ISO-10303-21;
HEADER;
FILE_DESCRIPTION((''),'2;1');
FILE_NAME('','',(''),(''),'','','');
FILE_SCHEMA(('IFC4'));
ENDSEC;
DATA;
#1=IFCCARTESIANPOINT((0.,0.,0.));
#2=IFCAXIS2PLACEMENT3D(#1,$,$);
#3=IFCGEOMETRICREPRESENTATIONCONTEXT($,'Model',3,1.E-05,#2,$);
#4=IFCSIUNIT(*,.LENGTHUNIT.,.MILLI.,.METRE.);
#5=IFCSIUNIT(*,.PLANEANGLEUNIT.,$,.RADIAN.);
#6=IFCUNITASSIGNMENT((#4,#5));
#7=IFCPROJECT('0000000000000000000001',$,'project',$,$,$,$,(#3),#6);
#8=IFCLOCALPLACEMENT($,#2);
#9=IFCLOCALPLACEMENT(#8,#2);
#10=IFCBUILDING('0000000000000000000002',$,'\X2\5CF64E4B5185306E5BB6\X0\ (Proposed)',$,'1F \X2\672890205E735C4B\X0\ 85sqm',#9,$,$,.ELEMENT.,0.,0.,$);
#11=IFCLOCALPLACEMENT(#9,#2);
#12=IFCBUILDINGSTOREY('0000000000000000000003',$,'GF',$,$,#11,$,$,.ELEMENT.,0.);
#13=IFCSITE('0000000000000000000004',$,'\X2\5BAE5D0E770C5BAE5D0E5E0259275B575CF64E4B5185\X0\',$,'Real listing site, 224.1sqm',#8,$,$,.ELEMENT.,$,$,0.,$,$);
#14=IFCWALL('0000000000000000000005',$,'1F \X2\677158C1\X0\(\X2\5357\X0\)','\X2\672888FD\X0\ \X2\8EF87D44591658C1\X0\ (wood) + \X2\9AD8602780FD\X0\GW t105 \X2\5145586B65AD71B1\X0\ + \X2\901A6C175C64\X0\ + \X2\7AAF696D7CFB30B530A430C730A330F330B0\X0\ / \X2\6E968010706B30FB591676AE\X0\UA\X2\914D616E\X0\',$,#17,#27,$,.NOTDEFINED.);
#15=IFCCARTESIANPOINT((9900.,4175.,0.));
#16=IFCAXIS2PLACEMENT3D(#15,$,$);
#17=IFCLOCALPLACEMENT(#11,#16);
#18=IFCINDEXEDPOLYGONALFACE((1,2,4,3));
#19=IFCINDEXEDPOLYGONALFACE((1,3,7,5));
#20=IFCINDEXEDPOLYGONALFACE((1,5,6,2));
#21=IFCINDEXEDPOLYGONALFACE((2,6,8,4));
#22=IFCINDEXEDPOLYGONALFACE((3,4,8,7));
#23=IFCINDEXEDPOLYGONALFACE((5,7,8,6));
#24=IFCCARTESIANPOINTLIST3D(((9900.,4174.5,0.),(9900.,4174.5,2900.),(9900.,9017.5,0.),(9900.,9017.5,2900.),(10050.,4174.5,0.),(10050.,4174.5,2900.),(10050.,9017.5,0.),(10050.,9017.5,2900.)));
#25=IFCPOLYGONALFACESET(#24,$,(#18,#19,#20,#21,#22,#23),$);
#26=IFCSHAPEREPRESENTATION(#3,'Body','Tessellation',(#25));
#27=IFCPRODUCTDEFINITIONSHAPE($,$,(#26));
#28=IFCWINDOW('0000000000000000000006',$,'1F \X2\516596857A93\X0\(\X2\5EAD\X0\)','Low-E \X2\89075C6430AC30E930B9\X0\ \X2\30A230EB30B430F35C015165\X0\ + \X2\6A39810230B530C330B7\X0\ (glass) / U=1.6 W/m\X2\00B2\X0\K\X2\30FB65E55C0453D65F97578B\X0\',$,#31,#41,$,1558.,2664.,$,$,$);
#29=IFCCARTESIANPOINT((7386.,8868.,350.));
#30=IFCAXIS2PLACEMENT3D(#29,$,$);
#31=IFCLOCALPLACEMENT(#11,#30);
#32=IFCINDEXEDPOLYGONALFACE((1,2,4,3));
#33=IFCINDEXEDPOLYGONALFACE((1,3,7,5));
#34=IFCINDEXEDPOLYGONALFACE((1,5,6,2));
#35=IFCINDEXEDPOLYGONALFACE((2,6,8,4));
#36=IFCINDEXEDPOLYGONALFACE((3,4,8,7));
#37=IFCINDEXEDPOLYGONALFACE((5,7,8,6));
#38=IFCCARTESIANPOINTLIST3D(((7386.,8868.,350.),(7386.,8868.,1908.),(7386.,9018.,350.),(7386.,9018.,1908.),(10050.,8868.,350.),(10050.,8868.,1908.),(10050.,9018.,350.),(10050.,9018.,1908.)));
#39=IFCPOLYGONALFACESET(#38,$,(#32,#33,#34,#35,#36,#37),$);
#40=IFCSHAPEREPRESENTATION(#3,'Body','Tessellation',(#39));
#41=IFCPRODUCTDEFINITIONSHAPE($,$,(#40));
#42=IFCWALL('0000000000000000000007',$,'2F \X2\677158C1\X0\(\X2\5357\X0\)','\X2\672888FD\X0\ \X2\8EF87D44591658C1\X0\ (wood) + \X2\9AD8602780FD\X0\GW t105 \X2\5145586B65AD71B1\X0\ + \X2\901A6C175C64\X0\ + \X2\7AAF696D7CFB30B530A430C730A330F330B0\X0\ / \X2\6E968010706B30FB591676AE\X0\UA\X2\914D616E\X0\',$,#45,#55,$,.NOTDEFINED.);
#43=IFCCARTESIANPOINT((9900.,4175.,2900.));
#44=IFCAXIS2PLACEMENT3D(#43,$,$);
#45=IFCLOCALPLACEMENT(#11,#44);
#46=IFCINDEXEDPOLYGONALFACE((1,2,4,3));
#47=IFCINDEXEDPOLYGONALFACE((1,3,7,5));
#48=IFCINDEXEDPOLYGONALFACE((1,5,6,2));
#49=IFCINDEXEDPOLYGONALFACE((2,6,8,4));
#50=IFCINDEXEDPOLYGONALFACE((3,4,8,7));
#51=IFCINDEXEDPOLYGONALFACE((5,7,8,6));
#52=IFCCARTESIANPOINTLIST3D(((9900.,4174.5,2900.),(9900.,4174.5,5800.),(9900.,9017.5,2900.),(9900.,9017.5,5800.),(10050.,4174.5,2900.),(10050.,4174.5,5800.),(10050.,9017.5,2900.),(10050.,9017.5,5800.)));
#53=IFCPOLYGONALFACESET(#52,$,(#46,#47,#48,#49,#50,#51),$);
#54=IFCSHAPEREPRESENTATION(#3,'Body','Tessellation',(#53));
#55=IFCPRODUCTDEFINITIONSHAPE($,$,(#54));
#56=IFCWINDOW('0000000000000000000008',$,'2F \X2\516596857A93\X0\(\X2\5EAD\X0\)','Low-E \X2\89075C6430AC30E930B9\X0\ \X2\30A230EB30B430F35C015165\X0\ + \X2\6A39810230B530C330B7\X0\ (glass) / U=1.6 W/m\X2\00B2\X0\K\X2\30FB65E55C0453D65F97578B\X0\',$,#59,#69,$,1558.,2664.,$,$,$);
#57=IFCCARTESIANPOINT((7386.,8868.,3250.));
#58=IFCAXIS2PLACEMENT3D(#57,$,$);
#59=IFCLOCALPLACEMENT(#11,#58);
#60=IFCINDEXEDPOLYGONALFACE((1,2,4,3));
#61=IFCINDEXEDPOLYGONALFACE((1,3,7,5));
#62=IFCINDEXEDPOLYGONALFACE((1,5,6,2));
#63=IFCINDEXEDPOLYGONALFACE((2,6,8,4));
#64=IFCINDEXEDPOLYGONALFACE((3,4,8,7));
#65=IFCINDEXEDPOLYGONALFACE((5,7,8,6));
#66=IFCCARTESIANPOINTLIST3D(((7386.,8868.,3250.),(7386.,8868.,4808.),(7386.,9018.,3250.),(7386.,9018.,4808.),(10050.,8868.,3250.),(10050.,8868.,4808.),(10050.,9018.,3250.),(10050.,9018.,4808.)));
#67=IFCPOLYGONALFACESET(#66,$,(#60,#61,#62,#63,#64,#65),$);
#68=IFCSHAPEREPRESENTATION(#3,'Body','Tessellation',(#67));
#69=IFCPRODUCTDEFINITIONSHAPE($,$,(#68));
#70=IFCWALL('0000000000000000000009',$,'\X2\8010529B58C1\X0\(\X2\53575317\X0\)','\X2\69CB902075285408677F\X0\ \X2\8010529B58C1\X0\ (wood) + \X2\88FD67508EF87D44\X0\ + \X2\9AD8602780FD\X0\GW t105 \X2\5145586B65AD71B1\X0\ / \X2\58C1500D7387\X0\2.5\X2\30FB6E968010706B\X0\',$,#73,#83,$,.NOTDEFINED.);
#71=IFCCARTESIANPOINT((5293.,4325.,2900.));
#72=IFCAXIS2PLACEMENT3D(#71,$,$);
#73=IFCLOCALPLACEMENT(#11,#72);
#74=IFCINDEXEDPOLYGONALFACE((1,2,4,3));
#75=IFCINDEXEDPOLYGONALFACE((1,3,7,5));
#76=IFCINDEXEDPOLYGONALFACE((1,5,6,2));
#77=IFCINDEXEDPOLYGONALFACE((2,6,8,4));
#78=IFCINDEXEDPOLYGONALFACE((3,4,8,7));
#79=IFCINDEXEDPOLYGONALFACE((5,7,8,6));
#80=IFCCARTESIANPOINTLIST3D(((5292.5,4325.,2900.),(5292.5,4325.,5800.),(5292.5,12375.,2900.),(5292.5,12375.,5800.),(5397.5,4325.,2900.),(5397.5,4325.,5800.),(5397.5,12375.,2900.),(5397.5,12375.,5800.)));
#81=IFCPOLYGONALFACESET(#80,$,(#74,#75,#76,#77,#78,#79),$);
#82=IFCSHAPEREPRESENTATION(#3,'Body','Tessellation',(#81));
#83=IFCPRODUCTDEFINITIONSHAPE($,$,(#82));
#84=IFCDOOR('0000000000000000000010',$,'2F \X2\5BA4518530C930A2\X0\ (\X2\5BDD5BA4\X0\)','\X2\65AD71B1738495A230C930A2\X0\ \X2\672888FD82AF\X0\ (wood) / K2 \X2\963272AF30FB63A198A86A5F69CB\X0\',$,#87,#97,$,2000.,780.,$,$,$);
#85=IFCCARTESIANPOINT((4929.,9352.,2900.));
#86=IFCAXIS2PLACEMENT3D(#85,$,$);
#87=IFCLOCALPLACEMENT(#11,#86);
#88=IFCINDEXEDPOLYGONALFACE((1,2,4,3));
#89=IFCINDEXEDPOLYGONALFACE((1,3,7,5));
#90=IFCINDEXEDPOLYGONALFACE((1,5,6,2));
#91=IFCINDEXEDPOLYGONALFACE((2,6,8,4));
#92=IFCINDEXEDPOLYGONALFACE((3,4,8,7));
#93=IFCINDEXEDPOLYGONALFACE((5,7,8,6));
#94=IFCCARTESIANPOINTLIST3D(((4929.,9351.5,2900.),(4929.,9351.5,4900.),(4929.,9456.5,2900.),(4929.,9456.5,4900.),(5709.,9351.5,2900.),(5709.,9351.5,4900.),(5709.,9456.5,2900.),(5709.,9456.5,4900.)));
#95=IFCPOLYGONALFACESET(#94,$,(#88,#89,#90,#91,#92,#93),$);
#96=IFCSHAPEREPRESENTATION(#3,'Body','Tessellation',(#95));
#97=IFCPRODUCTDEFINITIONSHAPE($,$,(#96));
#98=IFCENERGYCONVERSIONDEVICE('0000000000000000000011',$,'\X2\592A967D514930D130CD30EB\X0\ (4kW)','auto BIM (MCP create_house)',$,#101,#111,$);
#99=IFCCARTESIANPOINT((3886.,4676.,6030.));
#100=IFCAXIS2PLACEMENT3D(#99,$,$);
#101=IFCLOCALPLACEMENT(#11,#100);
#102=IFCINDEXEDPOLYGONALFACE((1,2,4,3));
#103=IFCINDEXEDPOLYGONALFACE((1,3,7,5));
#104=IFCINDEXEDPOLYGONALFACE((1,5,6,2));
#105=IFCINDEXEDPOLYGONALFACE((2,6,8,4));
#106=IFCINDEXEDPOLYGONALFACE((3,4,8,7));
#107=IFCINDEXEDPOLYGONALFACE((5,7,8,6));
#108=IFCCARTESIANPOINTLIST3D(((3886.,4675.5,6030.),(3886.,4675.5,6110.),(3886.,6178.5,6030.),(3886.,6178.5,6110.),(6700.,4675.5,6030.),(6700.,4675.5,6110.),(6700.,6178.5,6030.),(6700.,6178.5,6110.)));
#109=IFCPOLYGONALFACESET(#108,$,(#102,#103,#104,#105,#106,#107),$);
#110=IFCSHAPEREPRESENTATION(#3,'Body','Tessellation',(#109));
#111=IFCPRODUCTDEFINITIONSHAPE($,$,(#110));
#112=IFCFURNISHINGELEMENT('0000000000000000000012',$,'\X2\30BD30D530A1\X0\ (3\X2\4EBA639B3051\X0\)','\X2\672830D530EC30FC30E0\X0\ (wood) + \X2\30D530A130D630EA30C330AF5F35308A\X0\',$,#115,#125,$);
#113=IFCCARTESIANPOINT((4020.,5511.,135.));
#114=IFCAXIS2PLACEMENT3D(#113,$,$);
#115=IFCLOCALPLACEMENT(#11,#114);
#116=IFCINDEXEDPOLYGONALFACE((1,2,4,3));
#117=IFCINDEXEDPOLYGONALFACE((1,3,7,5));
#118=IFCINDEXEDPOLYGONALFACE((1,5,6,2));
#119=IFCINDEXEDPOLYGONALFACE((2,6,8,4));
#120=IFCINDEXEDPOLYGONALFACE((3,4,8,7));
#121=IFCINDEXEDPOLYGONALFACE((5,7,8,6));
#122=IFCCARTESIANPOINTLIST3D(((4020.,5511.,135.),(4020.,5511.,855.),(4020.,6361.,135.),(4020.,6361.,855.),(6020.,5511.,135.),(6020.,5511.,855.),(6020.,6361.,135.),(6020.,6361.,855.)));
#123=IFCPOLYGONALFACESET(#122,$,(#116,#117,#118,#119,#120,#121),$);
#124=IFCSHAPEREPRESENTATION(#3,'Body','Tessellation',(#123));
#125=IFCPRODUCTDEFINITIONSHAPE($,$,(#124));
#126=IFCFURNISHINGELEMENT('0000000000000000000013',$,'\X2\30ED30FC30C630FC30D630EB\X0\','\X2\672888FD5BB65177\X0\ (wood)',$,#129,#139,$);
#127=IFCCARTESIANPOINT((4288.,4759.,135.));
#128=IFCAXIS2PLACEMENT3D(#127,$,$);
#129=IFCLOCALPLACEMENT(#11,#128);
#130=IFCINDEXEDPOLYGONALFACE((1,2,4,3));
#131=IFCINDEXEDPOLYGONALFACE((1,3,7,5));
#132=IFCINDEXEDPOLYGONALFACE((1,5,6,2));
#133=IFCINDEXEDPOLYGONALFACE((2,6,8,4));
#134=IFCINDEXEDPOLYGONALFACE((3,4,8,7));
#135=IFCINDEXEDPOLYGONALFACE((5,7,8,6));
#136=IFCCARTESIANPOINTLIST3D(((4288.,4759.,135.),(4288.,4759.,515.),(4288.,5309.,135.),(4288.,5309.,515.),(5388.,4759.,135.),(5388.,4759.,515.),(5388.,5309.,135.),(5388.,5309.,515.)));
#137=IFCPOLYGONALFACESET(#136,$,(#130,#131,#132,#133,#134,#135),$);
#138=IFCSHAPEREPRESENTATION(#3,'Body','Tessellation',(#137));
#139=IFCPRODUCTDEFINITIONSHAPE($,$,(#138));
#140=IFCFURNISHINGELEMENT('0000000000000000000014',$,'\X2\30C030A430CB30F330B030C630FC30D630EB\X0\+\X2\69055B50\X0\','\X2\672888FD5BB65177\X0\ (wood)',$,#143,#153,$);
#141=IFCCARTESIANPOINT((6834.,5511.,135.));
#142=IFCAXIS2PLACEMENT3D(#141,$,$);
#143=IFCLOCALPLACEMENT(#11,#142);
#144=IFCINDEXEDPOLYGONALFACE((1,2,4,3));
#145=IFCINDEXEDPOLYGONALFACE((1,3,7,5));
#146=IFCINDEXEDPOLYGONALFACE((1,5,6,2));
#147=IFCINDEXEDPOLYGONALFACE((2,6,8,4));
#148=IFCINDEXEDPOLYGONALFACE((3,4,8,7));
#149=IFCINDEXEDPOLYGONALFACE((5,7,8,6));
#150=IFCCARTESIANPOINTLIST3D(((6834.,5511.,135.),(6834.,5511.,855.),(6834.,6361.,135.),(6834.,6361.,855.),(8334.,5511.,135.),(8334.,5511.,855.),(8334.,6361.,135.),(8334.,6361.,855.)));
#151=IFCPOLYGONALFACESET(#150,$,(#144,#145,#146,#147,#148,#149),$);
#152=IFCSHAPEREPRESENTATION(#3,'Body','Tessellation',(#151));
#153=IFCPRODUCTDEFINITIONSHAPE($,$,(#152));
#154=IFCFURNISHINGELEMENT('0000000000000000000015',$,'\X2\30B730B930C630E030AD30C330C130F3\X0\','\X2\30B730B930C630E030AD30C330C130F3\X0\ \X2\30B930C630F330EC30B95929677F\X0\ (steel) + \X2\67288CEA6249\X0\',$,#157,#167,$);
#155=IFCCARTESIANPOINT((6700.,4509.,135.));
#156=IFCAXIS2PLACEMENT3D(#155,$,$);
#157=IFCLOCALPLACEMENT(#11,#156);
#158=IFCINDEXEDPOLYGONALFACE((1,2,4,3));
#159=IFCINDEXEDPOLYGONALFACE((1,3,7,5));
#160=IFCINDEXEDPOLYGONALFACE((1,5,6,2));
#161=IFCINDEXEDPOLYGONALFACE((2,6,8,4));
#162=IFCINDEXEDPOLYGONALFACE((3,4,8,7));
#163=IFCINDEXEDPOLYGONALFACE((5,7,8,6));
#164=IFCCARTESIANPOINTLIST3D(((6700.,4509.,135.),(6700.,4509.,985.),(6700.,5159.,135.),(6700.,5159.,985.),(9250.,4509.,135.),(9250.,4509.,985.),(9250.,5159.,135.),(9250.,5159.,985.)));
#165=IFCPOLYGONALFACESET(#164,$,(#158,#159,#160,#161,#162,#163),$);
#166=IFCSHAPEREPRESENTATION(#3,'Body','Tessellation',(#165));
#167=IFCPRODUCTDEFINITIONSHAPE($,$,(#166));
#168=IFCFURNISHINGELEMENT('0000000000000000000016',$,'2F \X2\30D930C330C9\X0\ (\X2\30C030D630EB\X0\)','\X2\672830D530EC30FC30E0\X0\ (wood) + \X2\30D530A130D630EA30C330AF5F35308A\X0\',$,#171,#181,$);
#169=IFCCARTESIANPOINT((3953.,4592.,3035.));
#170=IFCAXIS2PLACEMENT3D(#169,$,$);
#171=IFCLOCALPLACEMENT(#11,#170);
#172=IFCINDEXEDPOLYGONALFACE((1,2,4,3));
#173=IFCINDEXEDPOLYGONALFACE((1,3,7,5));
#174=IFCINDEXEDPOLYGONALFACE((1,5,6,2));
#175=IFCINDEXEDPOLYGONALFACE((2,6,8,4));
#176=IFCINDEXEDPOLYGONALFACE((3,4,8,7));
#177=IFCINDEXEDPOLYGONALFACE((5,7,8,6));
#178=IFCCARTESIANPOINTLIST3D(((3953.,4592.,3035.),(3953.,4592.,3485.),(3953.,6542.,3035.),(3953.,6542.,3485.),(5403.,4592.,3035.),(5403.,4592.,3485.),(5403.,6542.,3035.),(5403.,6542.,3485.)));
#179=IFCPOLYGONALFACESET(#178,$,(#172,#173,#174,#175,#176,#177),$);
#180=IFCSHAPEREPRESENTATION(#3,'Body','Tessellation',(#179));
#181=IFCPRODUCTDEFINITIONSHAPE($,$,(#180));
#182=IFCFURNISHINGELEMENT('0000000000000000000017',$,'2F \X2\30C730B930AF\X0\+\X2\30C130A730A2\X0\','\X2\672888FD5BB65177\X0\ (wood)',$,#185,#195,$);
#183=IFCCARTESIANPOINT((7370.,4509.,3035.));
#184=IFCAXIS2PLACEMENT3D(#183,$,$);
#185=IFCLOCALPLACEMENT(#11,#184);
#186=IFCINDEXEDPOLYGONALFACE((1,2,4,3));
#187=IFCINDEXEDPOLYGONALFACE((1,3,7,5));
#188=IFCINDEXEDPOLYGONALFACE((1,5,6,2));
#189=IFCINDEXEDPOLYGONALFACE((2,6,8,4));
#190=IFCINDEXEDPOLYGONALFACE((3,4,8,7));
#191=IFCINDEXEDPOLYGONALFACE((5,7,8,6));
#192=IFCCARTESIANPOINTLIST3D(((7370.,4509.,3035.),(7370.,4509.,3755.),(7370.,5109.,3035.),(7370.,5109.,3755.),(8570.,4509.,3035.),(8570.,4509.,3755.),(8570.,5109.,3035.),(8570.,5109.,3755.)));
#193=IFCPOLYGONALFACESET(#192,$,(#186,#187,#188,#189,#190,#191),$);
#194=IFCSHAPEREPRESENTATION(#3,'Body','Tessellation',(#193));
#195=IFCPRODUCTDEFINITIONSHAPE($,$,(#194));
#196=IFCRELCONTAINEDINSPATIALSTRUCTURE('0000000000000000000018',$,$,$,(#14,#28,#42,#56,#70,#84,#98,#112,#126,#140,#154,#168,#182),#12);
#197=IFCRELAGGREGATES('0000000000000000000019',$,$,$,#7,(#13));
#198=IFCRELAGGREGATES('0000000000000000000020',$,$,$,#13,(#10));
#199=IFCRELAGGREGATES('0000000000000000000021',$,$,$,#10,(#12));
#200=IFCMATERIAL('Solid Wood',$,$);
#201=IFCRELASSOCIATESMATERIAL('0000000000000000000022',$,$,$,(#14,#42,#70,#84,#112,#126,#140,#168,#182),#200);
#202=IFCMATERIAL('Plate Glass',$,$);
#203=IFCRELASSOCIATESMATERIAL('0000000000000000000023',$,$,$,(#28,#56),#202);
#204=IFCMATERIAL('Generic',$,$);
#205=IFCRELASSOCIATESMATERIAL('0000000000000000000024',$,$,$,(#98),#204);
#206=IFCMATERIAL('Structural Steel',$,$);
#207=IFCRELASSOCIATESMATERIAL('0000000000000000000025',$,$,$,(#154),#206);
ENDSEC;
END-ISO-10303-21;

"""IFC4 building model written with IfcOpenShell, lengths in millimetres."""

from ifc_helpers import new_model, si_unit, frame, frame_2d, origin, place, context, project, spatial, rectangle, extrude, material, element, fill, save


model = new_model("IFC4")

# Units and contexts
model_context = context("Model", 3, precision=1e-05, world=origin())
ifc_project = project(units=[si_unit("LENGTHUNIT", "METRE", prefix="MILLI"), si_unit("PLANEANGLEUNIT", "RADIAN")], contexts=[model_context])

# Site, building, storey
site_placement = place(None, origin())
site = spatial("IfcSite", under=ifc_project, at=site_placement, Name="宮崎県宮崎市大字島之内", ObjectType="Real listing site, 224.1sqm", CompositionType="ELEMENT", RefElevation=0.0)
building_placement = place(site_placement, origin())
building = spatial("IfcBuilding", under=site, at=building_placement, Name="島之内の家 (Proposed)", ObjectType="1F 木造平屋 85sqm", CompositionType="ELEMENT", ElevationOfRefHeight=0.0, ElevationOfTerrain=0.0)
storey_placement = place(building_placement, origin())
storey = spatial("IfcBuildingStorey", under=building, at=storey_placement, Name="GF", CompositionType="ELEMENT", Elevation=0.0)

# Wall, opening, window
ifc_material_1 = material(Name="Solid Wood")
wall_1_placement = place(storey_placement, frame((9900.0, 4175.0, 0.0)))
wall_1 = element("IfcWall", 1, at=wall_1_placement, inside=storey, material=ifc_material_1, Name="1F 東壁(南)", Description="木製 軸組外壁 (wood) + 高性能GW t105 充填断熱 + 通気層 + 窯業系サイディング / 準耐火・外皮UA配慮", PredefinedType="NOTDEFINED", context=model_context, shape_type="SweptSolid", body=[
    extrude(rectangle(XDim=150.0, YDim=4843.0, at=frame_2d((75.0, 2421.0))), frame((9900.0, 4175.0, 0.0)), (0.0, 0.0, 1.0), 2900.0),
])
opening_1_placement = place(storey_placement, frame((7386.0, 8868.0, 350.0)))
opening_1 = element("IfcOpeningElement", 2, at=opening_1_placement, cuts=wall_1, PredefinedType="NOTDEFINED", context=model_context, shape_type="SweptSolid", body=[
    extrude(rectangle(XDim=2664.0, YDim=150.0, at=frame_2d((1332.0, 75.0))), frame((7386.0, 8868.0, 350.0)), (0.0, 0.0, 1.0), 1558.0),
])
ifc_material_2 = material(Name="Plate Glass")
window_1_placement = place(storey_placement, frame((7386.0, 8868.0, 350.0)))
window_1 = element("IfcWindow", 3, at=window_1_placement, inside=storey, material=ifc_material_2, Name="1F 入隅窓(庭)", Description="Low-E 複層ガラス アルゴン封入 + 樹脂サッシ (glass) / U=1.6 W/m²K・日射取得型", OverallHeight=1558.0, OverallWidth=2664.0, context=model_context, shape_type="SweptSolid", body=[
    extrude(rectangle(XDim=2664.0, YDim=150.0, at=frame_2d((1332.0, 75.0))), frame((7386.0, 8868.0, 350.0)), (0.0, 0.0, 1.0), 1558.0),
])
fill(opening_1, window_1)

# Wall, opening, window
wall_2_placement = place(storey_placement, frame((9900.0, 4175.0, 2900.0)))
wall_2 = element("IfcWall", 4, at=wall_2_placement, inside=storey, material=ifc_material_1, Name="2F 東壁(南)", Description="木製 軸組外壁 (wood) + 高性能GW t105 充填断熱 + 通気層 + 窯業系サイディング / 準耐火・外皮UA配慮", PredefinedType="NOTDEFINED", context=model_context, shape_type="SweptSolid", body=[
    extrude(rectangle(XDim=150.0, YDim=4843.0, at=frame_2d((75.0, 2421.0))), frame((9900.0, 4175.0, 2900.0)), (0.0, 0.0, 1.0), 2900.0),
])
opening_2_placement = place(storey_placement, frame((7386.0, 8868.0, 3250.0)))
opening_2 = element("IfcOpeningElement", 5, at=opening_2_placement, cuts=wall_2, PredefinedType="NOTDEFINED", context=model_context, shape_type="SweptSolid", body=[
    extrude(rectangle(XDim=2664.0, YDim=150.0, at=frame_2d((1332.0, 75.0))), frame((7386.0, 8868.0, 3250.0)), (0.0, 0.0, 1.0), 1558.0),
])
window_2_placement = place(storey_placement, frame((7386.0, 8868.0, 3250.0)))
window_2 = element("IfcWindow", 6, at=window_2_placement, inside=storey, material=ifc_material_2, Name="2F 入隅窓(庭)", Description="Low-E 複層ガラス アルゴン封入 + 樹脂サッシ (glass) / U=1.6 W/m²K・日射取得型", OverallHeight=1558.0, OverallWidth=2664.0, context=model_context, shape_type="SweptSolid", body=[
    extrude(rectangle(XDim=2664.0, YDim=150.0, at=frame_2d((1332.0, 75.0))), frame((7386.0, 8868.0, 3250.0)), (0.0, 0.0, 1.0), 1558.0),
])
fill(opening_2, window_2)

# Wall, opening, door
wall_3_placement = place(storey_placement, frame((5293.0, 4325.0, 2900.0)))
wall_3 = element("IfcWall", 7, at=wall_3_placement, inside=storey, material=ifc_material_1, Name="耐力壁(南北)", Description="構造用合板 耐力壁 (wood) + 製材軸組 + 高性能GW t105 充填断熱 / 壁倍率2.5・準耐火", PredefinedType="NOTDEFINED", context=model_context, shape_type="SweptSolid", body=[
    extrude(rectangle(XDim=105.0, YDim=8050.0, at=frame_2d((52.0, 4025.0))), frame((5293.0, 4325.0, 2900.0)), (0.0, 0.0, 1.0), 2900.0),
])
opening_3_placement = place(storey_placement, frame((4929.0, 9352.0, 2900.0)))
opening_3 = element("IfcOpeningElement", 8, at=opening_3_placement, cuts=wall_3, PredefinedType="NOTDEFINED", context=model_context, shape_type="SweptSolid", body=[
    extrude(rectangle(XDim=780.0, YDim=105.0, at=frame_2d((390.0, 52.0))), frame((4929.0, 9352.0, 2900.0)), (0.0, 0.0, 1.0), 2000.0),
])
door_1_placement = place(storey_placement, frame((4929.0, 9352.0, 2900.0)))
door_1 = element("IfcDoor", 9, at=door_1_placement, inside=storey, material=ifc_material_1, Name="2F 室内ドア (寝室)", Description="断熱玄関ドア 木製芯 (wood) / K2 防犯・採風機構", OverallHeight=2000.0, OverallWidth=780.0, context=model_context, shape_type="SweptSolid", body=[
    extrude(rectangle(XDim=780.0, YDim=105.0, at=frame_2d((390.0, 52.0))), frame((4929.0, 9352.0, 2900.0)), (0.0, 0.0, 1.0), 2000.0),
])
fill(opening_3, door_1)

# Energy conversion device
ifc_material_3 = material(Name="Generic")
energy_conversion_device_placement = place(storey_placement, frame((3886.0, 4676.0, 6030.0)))
element("IfcEnergyConversionDevice", 10, at=energy_conversion_device_placement, inside=storey, material=ifc_material_3, Name="太陽光パネル (4kW)", Description="auto BIM (MCP create_house)", context=model_context, shape_type="SweptSolid", body=[
    extrude(rectangle(XDim=2814.0, YDim=1503.0, at=frame_2d((1407.0, 751.0))), frame((3886.0, 4676.0, 6030.0)), (0.0, 0.0, 1.0), 80.0),
])

# Furnishing elements
furnishing_1_placement = place(storey_placement, frame((4020.0, 5511.0, 135.0)))
element("IfcFurnishingElement", 11, at=furnishing_1_placement, inside=storey, material=ifc_material_1, Name="ソファ (3人掛け)", Description="木フレーム (wood) + ファブリック張り", context=model_context, shape_type="SweptSolid", body=[
    extrude(rectangle(XDim=2000.0, YDim=850.0, at=frame_2d((1000.0, 425.0))), frame((4020.0, 5511.0, 135.0)), (0.0, 0.0, 1.0), 720.0),
])
furnishing_2_placement = place(storey_placement, frame((4288.0, 4759.0, 135.0)))
element("IfcFurnishingElement", 12, at=furnishing_2_placement, inside=storey, material=ifc_material_1, Name="ローテーブル", Description="木製家具 (wood)", context=model_context, shape_type="SweptSolid", body=[
    extrude(rectangle(XDim=1100.0, YDim=550.0, at=frame_2d((550.0, 275.0))), frame((4288.0, 4759.0, 135.0)), (0.0, 0.0, 1.0), 380.0),
])
furnishing_3_placement = place(storey_placement, frame((6834.0, 5511.0, 135.0)))
element("IfcFurnishingElement", 13, at=furnishing_3_placement, inside=storey, material=ifc_material_1, Name="ダイニングテーブル+椅子", Description="木製家具 (wood)", context=model_context, shape_type="SweptSolid", body=[
    extrude(rectangle(XDim=1500.0, YDim=850.0, at=frame_2d((750.0, 425.0))), frame((6834.0, 5511.0, 135.0)), (0.0, 0.0, 1.0), 720.0),
])
ifc_material_4 = material(Name="Structural Steel")
furnishing_4_placement = place(storey_placement, frame((6700.0, 4509.0, 135.0)))
element("IfcFurnishingElement", 14, at=furnishing_4_placement, inside=storey, material=ifc_material_4, Name="システムキッチン", Description="システムキッチン ステンレス天板 (steel) + 木質扉", context=model_context, shape_type="SweptSolid", body=[
    extrude(rectangle(XDim=2550.0, YDim=650.0, at=frame_2d((1275.0, 325.0))), frame((6700.0, 4509.0, 135.0)), (0.0, 0.0, 1.0), 850.0),
])
furnishing_5_placement = place(storey_placement, frame((3953.0, 4592.0, 3035.0)))
element("IfcFurnishingElement", 15, at=furnishing_5_placement, inside=storey, material=ifc_material_1, Name="2F ベッド (ダブル)", Description="木フレーム (wood) + ファブリック張り", context=model_context, shape_type="SweptSolid", body=[
    extrude(rectangle(XDim=1450.0, YDim=1950.0, at=frame_2d((725.0, 975.0))), frame((3953.0, 4592.0, 3035.0)), (0.0, 0.0, 1.0), 450.0),
])
furnishing_6_placement = place(storey_placement, frame((7370.0, 4509.0, 3035.0)))
element("IfcFurnishingElement", 16, at=furnishing_6_placement, inside=storey, material=ifc_material_1, Name="2F デスク+チェア", Description="木製家具 (wood)", context=model_context, shape_type="SweptSolid", body=[
    extrude(rectangle(XDim=1200.0, YDim=600.0, at=frame_2d((600.0, 300.0))), frame((7370.0, 4509.0, 3035.0)), (0.0, 0.0, 1.0), 720.0),
])

save(model, "model.ifc")
